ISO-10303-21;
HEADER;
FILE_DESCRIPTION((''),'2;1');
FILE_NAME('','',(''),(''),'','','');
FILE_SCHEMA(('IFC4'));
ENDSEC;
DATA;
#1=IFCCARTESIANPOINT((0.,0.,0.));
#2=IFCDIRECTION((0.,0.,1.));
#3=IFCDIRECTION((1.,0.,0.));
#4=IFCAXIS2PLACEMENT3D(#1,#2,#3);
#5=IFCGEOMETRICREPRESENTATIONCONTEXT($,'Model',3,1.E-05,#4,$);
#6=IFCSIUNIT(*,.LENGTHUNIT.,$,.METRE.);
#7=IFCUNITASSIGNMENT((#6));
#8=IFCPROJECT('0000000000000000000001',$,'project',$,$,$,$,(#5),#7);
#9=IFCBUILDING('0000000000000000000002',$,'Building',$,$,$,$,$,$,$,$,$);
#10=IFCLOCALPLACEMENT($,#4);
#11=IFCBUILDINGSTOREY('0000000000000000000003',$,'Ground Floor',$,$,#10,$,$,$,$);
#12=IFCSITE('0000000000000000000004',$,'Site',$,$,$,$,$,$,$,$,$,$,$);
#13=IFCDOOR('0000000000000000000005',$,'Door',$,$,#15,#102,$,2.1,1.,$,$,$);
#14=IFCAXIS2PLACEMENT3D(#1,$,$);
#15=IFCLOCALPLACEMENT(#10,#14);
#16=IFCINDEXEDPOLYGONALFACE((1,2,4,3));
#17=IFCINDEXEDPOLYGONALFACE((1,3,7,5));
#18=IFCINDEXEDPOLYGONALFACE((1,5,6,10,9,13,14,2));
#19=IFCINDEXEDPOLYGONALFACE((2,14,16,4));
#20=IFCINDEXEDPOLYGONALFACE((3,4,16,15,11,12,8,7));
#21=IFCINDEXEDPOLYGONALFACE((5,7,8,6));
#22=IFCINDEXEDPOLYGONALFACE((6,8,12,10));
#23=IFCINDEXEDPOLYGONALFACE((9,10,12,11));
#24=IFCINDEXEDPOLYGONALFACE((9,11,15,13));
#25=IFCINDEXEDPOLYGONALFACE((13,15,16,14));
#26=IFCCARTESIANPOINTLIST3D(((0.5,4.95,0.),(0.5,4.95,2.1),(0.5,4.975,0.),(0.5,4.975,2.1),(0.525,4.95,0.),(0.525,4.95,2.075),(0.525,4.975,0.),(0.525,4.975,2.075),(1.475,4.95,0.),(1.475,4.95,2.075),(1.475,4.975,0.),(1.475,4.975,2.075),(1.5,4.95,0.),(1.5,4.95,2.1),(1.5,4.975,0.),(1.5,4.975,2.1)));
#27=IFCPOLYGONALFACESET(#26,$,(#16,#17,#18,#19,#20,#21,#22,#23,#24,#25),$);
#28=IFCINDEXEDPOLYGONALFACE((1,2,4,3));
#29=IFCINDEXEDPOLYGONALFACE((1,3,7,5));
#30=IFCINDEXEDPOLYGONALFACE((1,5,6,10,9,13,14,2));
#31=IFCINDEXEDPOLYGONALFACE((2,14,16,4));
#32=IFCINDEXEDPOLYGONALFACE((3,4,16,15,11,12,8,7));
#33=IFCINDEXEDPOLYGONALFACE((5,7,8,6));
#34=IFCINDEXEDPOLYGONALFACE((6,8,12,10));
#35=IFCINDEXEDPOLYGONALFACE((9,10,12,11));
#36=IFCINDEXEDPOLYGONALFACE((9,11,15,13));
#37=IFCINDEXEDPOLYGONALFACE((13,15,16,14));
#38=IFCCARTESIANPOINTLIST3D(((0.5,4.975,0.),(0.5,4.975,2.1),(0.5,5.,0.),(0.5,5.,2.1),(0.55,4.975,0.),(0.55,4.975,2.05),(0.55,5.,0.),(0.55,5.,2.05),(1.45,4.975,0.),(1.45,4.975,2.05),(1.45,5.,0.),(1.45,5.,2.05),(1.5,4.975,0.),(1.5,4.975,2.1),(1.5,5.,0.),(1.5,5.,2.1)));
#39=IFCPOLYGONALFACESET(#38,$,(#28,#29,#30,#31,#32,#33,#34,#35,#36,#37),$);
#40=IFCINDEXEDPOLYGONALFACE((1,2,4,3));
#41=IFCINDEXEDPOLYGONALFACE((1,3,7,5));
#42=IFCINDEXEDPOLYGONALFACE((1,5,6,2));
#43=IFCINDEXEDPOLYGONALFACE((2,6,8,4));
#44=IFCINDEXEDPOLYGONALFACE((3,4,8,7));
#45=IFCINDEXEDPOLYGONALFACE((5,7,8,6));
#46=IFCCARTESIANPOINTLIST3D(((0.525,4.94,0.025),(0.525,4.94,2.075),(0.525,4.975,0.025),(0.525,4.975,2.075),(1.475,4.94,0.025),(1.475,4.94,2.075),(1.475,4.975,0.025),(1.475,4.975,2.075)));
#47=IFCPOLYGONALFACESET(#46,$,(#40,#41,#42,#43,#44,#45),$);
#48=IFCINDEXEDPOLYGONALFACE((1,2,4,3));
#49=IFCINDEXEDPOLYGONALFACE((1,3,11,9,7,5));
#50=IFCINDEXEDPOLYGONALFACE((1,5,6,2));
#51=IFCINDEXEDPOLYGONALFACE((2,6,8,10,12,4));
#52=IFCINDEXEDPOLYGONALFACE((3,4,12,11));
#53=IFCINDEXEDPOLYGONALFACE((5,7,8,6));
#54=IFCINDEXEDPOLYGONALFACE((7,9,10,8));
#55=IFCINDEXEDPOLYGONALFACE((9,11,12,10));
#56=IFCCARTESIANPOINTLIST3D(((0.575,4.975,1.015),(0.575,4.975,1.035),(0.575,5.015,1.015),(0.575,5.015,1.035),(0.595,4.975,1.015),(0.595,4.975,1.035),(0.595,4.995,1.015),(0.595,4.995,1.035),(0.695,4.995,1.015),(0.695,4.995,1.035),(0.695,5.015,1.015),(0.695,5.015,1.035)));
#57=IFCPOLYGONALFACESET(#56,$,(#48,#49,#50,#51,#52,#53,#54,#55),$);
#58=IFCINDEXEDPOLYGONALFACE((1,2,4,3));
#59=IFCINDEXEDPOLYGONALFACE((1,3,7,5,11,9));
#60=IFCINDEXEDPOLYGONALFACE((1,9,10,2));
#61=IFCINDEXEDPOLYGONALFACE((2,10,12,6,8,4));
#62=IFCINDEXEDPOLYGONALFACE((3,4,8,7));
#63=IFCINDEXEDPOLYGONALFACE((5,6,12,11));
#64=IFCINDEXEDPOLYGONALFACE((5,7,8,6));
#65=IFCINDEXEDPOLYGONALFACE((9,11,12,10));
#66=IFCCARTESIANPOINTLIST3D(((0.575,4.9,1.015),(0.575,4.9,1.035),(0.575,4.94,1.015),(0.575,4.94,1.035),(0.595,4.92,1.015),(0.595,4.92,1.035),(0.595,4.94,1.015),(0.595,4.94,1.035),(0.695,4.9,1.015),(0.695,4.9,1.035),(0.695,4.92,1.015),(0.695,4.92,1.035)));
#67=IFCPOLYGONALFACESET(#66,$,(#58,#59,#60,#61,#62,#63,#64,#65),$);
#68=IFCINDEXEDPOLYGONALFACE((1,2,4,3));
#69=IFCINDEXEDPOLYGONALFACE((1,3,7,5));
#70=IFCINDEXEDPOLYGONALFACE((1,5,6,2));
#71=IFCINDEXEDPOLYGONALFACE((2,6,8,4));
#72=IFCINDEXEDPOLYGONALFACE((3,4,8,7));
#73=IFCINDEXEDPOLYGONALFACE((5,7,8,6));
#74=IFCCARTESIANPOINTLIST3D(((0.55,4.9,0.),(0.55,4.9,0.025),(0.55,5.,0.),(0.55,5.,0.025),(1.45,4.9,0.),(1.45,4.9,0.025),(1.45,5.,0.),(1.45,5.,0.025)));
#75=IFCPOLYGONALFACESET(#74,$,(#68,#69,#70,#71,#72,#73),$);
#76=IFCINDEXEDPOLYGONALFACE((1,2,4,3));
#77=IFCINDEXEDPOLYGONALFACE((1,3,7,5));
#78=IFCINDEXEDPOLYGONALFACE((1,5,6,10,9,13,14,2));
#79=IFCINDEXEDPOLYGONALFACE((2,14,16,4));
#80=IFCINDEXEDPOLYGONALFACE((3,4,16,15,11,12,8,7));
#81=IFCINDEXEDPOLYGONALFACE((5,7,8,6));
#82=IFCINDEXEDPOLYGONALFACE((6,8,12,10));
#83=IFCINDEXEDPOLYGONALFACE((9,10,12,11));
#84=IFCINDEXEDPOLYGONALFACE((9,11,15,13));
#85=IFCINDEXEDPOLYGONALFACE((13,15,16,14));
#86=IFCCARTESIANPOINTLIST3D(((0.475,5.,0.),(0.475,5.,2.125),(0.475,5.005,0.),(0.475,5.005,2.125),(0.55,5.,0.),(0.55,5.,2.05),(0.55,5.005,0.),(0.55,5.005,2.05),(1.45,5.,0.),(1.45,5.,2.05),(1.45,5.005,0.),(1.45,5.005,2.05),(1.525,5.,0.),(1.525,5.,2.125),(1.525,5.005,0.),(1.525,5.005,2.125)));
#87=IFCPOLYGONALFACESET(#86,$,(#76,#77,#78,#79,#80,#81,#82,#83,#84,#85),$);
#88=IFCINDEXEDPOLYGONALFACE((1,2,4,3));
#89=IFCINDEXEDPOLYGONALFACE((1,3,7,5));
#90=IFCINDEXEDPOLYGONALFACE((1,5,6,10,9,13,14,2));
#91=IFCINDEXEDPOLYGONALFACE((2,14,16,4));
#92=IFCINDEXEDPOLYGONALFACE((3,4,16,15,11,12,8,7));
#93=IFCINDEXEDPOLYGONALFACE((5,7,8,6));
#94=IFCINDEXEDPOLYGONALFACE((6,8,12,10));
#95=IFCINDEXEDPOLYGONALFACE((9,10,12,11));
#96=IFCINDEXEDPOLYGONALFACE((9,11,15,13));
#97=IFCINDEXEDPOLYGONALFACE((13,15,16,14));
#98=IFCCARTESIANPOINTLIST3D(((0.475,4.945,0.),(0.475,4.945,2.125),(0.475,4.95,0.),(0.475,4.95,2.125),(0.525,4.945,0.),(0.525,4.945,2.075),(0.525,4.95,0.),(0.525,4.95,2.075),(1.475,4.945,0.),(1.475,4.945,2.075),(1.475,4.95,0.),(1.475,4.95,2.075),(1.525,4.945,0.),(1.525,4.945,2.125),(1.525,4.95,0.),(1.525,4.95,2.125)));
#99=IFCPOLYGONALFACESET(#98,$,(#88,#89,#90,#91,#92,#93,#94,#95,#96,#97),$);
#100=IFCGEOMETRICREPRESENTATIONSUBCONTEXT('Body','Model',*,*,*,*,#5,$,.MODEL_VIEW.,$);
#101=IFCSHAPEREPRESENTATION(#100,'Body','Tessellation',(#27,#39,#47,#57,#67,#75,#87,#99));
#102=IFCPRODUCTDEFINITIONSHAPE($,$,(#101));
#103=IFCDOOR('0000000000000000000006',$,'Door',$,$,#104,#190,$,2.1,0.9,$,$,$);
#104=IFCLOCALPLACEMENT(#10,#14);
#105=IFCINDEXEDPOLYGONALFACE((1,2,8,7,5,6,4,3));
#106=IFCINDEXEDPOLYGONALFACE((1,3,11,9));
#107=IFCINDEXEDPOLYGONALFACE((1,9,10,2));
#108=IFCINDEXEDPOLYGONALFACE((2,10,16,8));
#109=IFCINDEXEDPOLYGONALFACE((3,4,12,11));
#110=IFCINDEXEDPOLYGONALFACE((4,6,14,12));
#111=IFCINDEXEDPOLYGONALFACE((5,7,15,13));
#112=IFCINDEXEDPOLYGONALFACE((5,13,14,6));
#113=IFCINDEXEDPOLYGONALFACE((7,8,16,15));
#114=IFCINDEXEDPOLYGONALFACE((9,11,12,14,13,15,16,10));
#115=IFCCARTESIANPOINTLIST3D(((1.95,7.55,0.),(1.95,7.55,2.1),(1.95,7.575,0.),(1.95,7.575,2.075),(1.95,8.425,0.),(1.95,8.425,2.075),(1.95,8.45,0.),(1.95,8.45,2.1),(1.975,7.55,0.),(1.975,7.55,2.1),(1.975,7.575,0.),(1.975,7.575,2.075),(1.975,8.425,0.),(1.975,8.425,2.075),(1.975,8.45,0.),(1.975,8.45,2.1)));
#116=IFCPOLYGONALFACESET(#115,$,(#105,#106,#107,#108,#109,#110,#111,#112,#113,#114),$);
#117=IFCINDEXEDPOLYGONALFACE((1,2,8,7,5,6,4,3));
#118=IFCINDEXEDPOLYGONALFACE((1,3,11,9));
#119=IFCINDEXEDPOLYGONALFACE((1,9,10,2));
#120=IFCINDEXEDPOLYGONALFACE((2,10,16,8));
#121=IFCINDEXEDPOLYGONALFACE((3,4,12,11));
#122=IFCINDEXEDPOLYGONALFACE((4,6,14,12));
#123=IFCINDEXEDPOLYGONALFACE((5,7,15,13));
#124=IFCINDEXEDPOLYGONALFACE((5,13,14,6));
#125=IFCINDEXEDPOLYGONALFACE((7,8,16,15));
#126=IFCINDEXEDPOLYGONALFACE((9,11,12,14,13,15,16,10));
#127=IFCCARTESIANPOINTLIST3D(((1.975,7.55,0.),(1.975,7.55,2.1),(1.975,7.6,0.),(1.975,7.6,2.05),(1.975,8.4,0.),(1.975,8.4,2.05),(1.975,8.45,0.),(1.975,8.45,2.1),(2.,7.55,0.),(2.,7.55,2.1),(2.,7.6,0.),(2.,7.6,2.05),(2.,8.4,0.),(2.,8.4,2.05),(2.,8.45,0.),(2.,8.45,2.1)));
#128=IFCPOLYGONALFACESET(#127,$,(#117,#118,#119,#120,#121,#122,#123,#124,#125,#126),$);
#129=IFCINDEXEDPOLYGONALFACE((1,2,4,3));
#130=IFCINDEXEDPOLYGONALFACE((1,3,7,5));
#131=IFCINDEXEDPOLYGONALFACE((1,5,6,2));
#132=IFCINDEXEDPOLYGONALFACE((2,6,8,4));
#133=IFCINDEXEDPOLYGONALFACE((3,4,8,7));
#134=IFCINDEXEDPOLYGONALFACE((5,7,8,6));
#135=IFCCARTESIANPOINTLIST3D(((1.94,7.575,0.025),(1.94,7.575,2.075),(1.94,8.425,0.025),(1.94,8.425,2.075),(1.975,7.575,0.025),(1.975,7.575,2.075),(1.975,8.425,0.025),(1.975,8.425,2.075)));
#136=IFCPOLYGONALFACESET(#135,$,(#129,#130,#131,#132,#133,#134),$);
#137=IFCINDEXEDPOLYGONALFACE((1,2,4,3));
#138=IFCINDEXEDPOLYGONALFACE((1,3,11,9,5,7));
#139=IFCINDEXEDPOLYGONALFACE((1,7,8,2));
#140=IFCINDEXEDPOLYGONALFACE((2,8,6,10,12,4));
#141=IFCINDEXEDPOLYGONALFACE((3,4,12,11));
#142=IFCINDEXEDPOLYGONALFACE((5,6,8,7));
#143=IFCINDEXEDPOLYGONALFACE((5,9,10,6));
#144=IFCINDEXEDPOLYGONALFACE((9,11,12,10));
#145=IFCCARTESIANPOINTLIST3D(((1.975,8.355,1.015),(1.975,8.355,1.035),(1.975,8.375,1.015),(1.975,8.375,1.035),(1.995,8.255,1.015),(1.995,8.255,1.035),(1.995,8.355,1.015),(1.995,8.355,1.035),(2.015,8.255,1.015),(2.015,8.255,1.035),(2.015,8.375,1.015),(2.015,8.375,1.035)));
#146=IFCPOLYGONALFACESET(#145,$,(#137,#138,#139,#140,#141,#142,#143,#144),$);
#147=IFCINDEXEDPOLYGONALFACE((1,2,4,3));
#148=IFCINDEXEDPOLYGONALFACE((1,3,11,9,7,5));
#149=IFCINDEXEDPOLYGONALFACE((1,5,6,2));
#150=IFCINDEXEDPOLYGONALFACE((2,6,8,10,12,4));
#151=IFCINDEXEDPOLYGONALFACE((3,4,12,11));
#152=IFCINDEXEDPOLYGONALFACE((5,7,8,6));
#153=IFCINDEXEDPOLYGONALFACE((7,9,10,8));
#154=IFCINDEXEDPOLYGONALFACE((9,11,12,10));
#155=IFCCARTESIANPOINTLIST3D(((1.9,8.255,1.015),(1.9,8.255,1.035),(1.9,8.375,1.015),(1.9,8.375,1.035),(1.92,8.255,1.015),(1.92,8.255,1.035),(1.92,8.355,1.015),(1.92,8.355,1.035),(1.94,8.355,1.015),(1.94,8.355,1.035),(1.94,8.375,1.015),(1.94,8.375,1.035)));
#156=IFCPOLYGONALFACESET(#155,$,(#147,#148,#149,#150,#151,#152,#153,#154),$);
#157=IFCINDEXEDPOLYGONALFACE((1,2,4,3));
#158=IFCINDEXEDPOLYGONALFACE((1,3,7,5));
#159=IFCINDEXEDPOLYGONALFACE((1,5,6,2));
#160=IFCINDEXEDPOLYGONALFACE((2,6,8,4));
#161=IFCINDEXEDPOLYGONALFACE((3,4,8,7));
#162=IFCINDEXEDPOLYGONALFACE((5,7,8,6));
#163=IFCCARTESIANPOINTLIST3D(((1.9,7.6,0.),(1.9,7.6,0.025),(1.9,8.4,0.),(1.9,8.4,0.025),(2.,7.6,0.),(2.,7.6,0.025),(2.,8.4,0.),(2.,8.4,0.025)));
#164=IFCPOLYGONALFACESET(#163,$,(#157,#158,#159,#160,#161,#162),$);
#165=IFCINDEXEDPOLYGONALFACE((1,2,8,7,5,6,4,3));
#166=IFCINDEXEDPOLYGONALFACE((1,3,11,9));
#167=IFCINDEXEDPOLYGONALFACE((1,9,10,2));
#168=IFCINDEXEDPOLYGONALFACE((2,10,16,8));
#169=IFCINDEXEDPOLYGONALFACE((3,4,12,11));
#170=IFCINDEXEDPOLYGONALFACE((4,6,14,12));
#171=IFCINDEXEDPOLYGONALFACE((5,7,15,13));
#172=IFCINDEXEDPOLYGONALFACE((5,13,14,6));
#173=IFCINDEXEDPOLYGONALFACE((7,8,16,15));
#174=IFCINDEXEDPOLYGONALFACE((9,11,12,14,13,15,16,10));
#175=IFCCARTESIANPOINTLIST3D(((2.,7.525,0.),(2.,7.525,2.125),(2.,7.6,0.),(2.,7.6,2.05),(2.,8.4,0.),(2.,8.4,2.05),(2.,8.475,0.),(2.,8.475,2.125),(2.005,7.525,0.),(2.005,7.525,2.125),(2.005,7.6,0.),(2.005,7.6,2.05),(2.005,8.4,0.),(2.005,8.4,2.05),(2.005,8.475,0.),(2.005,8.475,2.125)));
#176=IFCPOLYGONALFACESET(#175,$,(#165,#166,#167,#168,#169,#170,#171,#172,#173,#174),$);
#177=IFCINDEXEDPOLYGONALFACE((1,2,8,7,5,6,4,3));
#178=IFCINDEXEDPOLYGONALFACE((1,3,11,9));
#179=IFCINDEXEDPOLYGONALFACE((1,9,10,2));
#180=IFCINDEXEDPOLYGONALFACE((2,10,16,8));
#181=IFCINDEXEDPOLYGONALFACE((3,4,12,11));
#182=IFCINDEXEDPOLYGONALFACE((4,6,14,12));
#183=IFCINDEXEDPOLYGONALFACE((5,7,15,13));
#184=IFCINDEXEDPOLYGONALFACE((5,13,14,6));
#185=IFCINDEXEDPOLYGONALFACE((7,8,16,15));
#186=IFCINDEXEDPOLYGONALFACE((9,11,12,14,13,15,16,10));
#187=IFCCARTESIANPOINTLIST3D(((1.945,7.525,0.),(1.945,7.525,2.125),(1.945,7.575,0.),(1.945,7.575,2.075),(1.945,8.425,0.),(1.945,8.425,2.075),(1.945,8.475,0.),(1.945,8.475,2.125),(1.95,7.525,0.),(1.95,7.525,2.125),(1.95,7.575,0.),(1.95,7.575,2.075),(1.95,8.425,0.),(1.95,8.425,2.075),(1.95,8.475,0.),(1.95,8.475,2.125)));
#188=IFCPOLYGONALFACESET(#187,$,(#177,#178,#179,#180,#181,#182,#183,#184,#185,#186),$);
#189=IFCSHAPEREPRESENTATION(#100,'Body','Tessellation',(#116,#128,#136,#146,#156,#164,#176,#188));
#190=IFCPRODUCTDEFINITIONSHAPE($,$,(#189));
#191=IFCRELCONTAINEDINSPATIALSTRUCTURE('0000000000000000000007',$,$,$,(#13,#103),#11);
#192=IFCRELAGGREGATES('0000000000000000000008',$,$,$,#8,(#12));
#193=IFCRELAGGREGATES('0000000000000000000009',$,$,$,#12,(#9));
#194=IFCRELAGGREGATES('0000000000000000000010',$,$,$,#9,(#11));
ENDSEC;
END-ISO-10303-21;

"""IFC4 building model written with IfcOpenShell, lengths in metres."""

from ifc_helpers import new_model, si_unit, frame, origin_with_axes, place, context, subcontext, project, spatial, line, indexed_curve, outline, extrude, element, save


model = new_model("IFC4")

# Units and contexts
model_context = context("Model", 3, precision=1e-05, world=origin_with_axes())
body_context = subcontext(model_context, "Body", "Model", "MODEL_VIEW")
ifc_project = project(units=[si_unit("LENGTHUNIT", "METRE")], contexts=[model_context])

# Site, building, storey
site = spatial("IfcSite", under=ifc_project, Name="Site")
building = spatial("IfcBuilding", under=site, Name="Building")
storey_placement = place(None, origin_with_axes())
storey = spatial("IfcBuildingStorey", under=building, at=storey_placement, Name="Ground Floor")

# Doors
door_1_placement = place(storey_placement, frame((1.5, 5.0, 0.0), z_axis=(0.0, 0.0, 1.0), x_axis=(-1.0, 0.0, 0.0)))
element("IfcDoor", 1, at=door_1_placement, inside=storey, Name="Door", OverallHeight=2.1, OverallWidth=1.0, context=body_context, shape_type="SweptSolid", body=[
    extrude(outline(indexed_curve([(0.0, 0.0), (0.0, 2.1), (1.0, 2.1), (1.0, 0.0), (0.975, 0.0), (0.975, 2.075), (0.025, 2.075), (0.025, 0.0)], segments=[line(1, 2, 3, 4, 5, 6, 7, 8, 1)])), frame((0.0, 0.025, 0.0), z_axis=(0.0, -1.0, 0.0), x_axis=(1.0, 0.0, 0.0)), (0.0, 0.0, -1.0), 0.025),
    extrude(outline(indexed_curve([(0.0, 0.0), (0.0, 2.1), (1.0, 2.1), (1.0, 0.0), (0.95, 0.0), (0.95, 2.05), (0.05, 2.05), (0.05, 0.0)], segments=[line(1, 2, 3, 4, 5, 6, 7, 8, 1)])), frame((0.0, 0.0, 0.0), z_axis=(0.0, -1.0, 0.0), x_axis=(1.0, 0.0, 0.0)), (0.0, 0.0, -1.0), 0.025),
    extrude(outline(indexed_curve([(0.0, 0.0), (0.95, 0.0), (0.95, 0.035), (0.0, 0.035)], segments=[line(1, 2, 3, 4, 1)])), frame((0.025, 0.025, 0.025), z_axis=(0.0, 0.0, 1.0), x_axis=(1.0, 0.0, 0.0)), (0.0, 0.0, 1.0), 2.05),
    extrude(outline(indexed_curve([(0.0, 0.0), (0.0, -0.04), (-0.12, -0.04), (-0.12, -0.02), (-0.02, -0.02), (-0.02, 0.0)], segments=[line(1, 2, 3, 4, 5, 6, 1)])), frame((0.925, 0.025, 1.015), z_axis=(0.0, 0.0, 1.0), x_axis=(1.0, 0.0, 0.0)), (0.0, 0.0, 1.0), 0.02),
    extrude(outline(indexed_curve([(0.0, 0.0), (0.0, 0.04), (-0.12, 0.04), (-0.12, 0.02), (-0.02, 0.02), (-0.02, 0.0)], segments=[line(1, 2, 3, 4, 5, 6, 1)])), frame((0.925, 0.06, 1.015), z_axis=(0.0, 0.0, 1.0), x_axis=(1.0, 0.0, 0.0)), (0.0, 0.0, 1.0), 0.02),
    extrude(outline(indexed_curve([(0.0, 0.0), (0.9, 0.0), (0.9, 0.1), (0.0, 0.1)], segments=[line(1, 2, 3, 4, 1)])), frame((0.05, 0.0, 0.0), z_axis=(0.0, 0.0, 1.0), x_axis=(1.0, 0.0, 0.0)), (0.0, 0.0, 1.0), 0.025),
    extrude(outline(indexed_curve([(0.0, 0.0), (0.0, 2.125), (1.05, 2.125), (1.05, 0.0), (0.975, 0.0), (0.975, 2.05), (0.075, 2.05), (0.075, 0.0)], segments=[line(1, 2, 3, 4, 5, 6, 7, 8, 1)])), frame((-0.025, -0.005, 0.0), z_axis=(0.0, -1.0, 0.0), x_axis=(1.0, 0.0, 0.0)), (0.0, 0.0, -1.0), 0.005),
    extrude(outline(indexed_curve([(0.0, 0.0), (0.0, 2.125), (1.05, 2.125), (1.05, 0.0), (1.0, 0.0), (1.0, 2.075), (0.05, 2.075), (0.05, 0.0)], segments=[line(1, 2, 3, 4, 5, 6, 7, 8, 1)])), frame((-0.025, 0.05, 0.0), z_axis=(0.0, -1.0, 0.0), x_axis=(1.0, 0.0, 0.0)), (0.0, 0.0, -1.0), 0.005),
])
door_2_placement = place(storey_placement, frame((2.0, 7.55, 0.0), z_axis=(0.0, 0.0, 1.0), x_axis=(0.0, 1.0, 0.0)))
element("IfcDoor", 2, at=door_2_placement, inside=storey, Name="Door", OverallHeight=2.1, OverallWidth=0.9, context=body_context, shape_type="SweptSolid", body=[
    extrude(outline(indexed_curve([(0.0, 0.0), (0.0, 2.1), (0.9, 2.1), (0.9, 0.0), (0.875, 0.0), (0.875, 2.075), (0.025, 2.075), (0.025, 0.0)], segments=[line(1, 2, 3, 4, 5, 6, 7, 8, 1)])), frame((0.0, 0.025, 0.0), z_axis=(0.0, -1.0, 0.0), x_axis=(1.0, 0.0, 0.0)), (0.0, 0.0, -1.0), 0.025),
    extrude(outline(indexed_curve([(0.0, 0.0), (0.0, 2.1), (0.9, 2.1), (0.9, 0.0), (0.85, 0.0), (0.85, 2.05), (0.05, 2.05), (0.05, 0.0)], segments=[line(1, 2, 3, 4, 5, 6, 7, 8, 1)])), frame((0.0, 0.0, 0.0), z_axis=(0.0, -1.0, 0.0), x_axis=(1.0, 0.0, 0.0)), (0.0, 0.0, -1.0), 0.025),
    extrude(outline(indexed_curve([(0.0, 0.0), (0.85, 0.0), (0.85, 0.035), (0.0, 0.035)], segments=[line(1, 2, 3, 4, 1)])), frame((0.025, 0.025, 0.025), z_axis=(0.0, 0.0, 1.0), x_axis=(1.0, 0.0, 0.0)), (0.0, 0.0, 1.0), 2.05),
    extrude(outline(indexed_curve([(0.0, 0.0), (0.0, -0.04), (-0.12, -0.04), (-0.12, -0.02), (-0.02, -0.02), (-0.02, 0.0)], segments=[line(1, 2, 3, 4, 5, 6, 1)])), frame((0.825, 0.025, 1.015), z_axis=(0.0, 0.0, 1.0), x_axis=(1.0, 0.0, 0.0)), (0.0, 0.0, 1.0), 0.02),
    extrude(outline(indexed_curve([(0.0, 0.0), (0.0, 0.04), (-0.12, 0.04), (-0.12, 0.02), (-0.02, 0.02), (-0.02, 0.0)], segments=[line(1, 2, 3, 4, 5, 6, 1)])), frame((0.825, 0.06, 1.015), z_axis=(0.0, 0.0, 1.0), x_axis=(1.0, 0.0, 0.0)), (0.0, 0.0, 1.0), 0.02),
    extrude(outline(indexed_curve([(0.0, 0.0), (0.8, 0.0), (0.8, 0.1), (0.0, 0.1)], segments=[line(1, 2, 3, 4, 1)])), frame((0.05, 0.0, 0.0), z_axis=(0.0, 0.0, 1.0), x_axis=(1.0, 0.0, 0.0)), (0.0, 0.0, 1.0), 0.025),
    extrude(outline(indexed_curve([(0.0, 0.0), (0.0, 2.125), (0.95, 2.125), (0.95, 0.0), (0.875, 0.0), (0.875, 2.05), (0.075, 2.05), (0.075, 0.0)], segments=[line(1, 2, 3, 4, 5, 6, 7, 8, 1)])), frame((-0.025, -0.005, 0.0), z_axis=(0.0, -1.0, 0.0), x_axis=(1.0, 0.0, 0.0)), (0.0, 0.0, -1.0), 0.005),
    extrude(outline(indexed_curve([(0.0, 0.0), (0.0, 2.125), (0.95, 2.125), (0.95, 0.0), (0.9, 0.0), (0.9, 2.075), (0.05, 2.075), (0.05, 0.0)], segments=[line(1, 2, 3, 4, 5, 6, 7, 8, 1)])), frame((-0.025, 0.05, 0.0), z_axis=(0.0, -1.0, 0.0), x_axis=(1.0, 0.0, 0.0)), (0.0, 0.0, -1.0), 0.005),
])

save(model, "model.ifc")
